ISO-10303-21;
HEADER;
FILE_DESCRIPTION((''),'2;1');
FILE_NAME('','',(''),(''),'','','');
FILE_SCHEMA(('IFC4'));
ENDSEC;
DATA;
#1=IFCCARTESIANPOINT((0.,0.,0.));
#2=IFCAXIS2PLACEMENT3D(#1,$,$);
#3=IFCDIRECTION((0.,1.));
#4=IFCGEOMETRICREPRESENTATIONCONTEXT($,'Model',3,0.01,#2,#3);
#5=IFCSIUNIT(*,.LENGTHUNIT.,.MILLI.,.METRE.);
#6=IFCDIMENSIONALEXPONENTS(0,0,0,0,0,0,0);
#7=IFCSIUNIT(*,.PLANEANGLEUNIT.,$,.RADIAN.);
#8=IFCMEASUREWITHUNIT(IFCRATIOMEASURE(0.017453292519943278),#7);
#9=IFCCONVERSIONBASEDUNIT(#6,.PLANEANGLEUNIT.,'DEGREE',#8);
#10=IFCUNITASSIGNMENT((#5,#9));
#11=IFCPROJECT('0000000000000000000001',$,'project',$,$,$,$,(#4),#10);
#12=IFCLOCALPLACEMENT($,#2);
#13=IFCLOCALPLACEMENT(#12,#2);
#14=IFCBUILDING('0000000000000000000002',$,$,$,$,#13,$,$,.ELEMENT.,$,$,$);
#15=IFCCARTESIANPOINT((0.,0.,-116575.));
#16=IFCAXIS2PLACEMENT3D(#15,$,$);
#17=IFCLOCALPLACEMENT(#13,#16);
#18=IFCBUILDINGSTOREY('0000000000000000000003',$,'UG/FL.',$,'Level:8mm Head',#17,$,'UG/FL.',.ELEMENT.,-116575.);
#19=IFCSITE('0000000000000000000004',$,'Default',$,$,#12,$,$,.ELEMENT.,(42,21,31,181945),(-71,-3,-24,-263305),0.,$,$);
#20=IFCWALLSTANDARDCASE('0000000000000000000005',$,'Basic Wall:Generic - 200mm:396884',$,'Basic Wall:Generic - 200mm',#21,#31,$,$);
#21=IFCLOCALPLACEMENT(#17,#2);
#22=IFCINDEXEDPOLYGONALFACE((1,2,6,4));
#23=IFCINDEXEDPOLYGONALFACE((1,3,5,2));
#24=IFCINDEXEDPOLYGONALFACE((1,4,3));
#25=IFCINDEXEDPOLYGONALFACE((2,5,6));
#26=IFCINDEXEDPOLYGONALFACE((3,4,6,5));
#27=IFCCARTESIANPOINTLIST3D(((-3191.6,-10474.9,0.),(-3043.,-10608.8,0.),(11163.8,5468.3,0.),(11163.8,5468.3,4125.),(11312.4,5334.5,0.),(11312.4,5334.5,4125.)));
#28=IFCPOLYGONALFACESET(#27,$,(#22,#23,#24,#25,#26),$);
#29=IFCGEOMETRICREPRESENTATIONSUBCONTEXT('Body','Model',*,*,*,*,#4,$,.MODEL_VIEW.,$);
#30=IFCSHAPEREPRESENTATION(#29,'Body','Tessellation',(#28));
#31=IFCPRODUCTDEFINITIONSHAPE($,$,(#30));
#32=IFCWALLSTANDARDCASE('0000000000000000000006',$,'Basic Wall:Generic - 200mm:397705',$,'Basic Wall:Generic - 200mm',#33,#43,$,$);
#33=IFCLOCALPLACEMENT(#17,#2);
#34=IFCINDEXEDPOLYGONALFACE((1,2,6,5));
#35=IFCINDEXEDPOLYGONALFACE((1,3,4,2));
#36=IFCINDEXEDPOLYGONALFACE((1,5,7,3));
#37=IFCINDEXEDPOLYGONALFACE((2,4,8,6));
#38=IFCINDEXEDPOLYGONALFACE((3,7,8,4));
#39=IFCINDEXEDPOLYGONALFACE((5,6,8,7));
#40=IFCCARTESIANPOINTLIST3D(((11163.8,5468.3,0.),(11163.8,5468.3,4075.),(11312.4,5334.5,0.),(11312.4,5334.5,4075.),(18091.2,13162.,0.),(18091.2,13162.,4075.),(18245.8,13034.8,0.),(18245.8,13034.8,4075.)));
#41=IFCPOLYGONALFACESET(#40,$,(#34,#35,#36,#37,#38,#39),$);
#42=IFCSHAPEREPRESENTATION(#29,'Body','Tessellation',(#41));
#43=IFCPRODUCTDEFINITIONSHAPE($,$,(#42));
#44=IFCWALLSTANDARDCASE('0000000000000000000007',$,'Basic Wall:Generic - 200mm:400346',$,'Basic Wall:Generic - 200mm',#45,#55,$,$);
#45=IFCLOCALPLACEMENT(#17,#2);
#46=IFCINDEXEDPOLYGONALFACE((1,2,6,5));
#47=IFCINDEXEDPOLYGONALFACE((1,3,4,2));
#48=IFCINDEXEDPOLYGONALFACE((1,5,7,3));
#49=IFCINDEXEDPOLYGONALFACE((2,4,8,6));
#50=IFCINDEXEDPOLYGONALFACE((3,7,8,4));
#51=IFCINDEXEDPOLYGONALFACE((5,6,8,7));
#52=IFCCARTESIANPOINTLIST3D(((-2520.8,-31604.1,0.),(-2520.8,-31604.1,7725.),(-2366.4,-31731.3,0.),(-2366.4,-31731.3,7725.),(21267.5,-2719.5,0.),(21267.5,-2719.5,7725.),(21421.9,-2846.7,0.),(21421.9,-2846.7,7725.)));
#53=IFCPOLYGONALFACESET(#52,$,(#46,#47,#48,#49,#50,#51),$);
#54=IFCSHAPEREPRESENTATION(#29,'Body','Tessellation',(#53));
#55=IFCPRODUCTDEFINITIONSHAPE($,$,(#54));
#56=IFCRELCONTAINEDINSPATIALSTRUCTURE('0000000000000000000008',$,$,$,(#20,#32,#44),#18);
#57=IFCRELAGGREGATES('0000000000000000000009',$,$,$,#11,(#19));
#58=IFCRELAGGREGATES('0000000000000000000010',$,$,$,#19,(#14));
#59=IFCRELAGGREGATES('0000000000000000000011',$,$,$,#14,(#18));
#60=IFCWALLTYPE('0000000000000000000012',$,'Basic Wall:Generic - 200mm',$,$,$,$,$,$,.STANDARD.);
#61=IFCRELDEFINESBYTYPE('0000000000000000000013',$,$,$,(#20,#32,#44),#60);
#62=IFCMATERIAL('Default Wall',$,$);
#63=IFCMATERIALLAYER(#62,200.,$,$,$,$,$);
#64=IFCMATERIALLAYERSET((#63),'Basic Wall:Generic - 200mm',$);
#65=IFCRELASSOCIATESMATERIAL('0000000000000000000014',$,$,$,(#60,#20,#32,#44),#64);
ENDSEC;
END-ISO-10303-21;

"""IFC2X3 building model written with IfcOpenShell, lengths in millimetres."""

from ifc_helpers import new_model, entity, si_unit, converted_unit, direction, frame, frame_2d, origin, place, context, subcontext, project, spatial, polyline, rectangle, outline, extrude, clip, halfspace, material, layer, layer_set, layer_usage, type_object, element, save


model = new_model("IFC2X3")

# Units and contexts
model_context = context("Model", 3, precision=0.01, world=origin(), true_north=direction((0.0, 1.0)))
body_context = subcontext(model_context, "Body", "Model", "MODEL_VIEW")
ifc_project = project(units=[si_unit("LENGTHUNIT", "METRE", prefix="MILLI"), converted_unit("PLANEANGLEUNIT", "DEGREE", entity("IfcRatioMeasure", 0.017453292519943278), si_unit("PLANEANGLEUNIT", "RADIAN"), dimensions=[0, 0, 0, 0, 0, 0, 0])], contexts=[model_context])

# Site, building, storey
site_placement = place(None, origin())
site = spatial("IfcSite", under=ifc_project, at=site_placement, Name="Default", CompositionType="ELEMENT", RefLatitude=(42, 21, 31, 181945), RefLongitude=(-71, -3, -24, -263305), RefElevation=0.0)
building_placement = place(site_placement, origin())
building = spatial("IfcBuilding", under=site, at=building_placement, CompositionType="ELEMENT")
storey_placement = place(building_placement, frame((0.0, 0.0, -116575.0)))
storey = spatial("IfcBuildingStorey", under=building, at=storey_placement, Name="UG/FL.", ObjectType="Level:8mm Head", LongName="UG/FL.", CompositionType="ELEMENT", Elevation=-116575.0)

# Walls
ifc_material = material(Name="Default Wall")
ifc_layer = layer(ifc_material, 200.0)
ifc_layer_set = layer_set([ifc_layer], Name="Basic Wall:Generic - 200mm")
ifc_layer_usage = layer_usage(ifc_layer_set, "AXIS2", "NEGATIVE", 100.0)
wall_type = type_object("IfcWallType", Name="Basic Wall:Generic - 200mm", PredefinedType="STANDARD", material=ifc_layer_set)
wall_1_placement = place(storey_placement, frame((-3117.3, -10541.9, 0.0), z_axis=(0.0, 0.0, 1.0), x_axis=(0.669131, 0.743145, 0.0)))
element("IfcWallStandardCase", 1, at=wall_1_placement, inside=storey, type_object=wall_type, material=ifc_layer_usage, Name="Basic Wall:Generic - 200mm:396884", ObjectType="Basic Wall:Generic - 200mm", context=body_context, shape_type="Clipping", body=[
    clip(extrude(rectangle(XDim=36016.3, YDim=200.0, at=frame_2d((3445.6, 0.0), x_axis=(1.0, 0.0))), origin(), (0.0, 0.0, 1.0), 4125.0), halfspace(frame((0.0, -100.0, 0.0), z_axis=(-0.188816, 0.0, 0.982013), x_axis=(0.0, 1.0, 0.0)), False)),
])
wall_2_placement = place(storey_placement, frame((11238.1, 5401.4, 0.0), z_axis=(0.0, 0.0, 1.0), x_axis=(0.669131, 0.743145, 0.0)))
element("IfcWallStandardCase", 2, at=wall_2_placement, inside=storey, type_object=wall_type, material=ifc_layer_usage, Name="Basic Wall:Generic - 200mm:397705", ObjectType="Basic Wall:Generic - 200mm", context=body_context, shape_type="SweptSolid", body=[
    extrude(outline(polyline([(10361.9, -100.0), (10352.9, 100.0), (0.0, 100.0), (0.0, -100.0), (10361.9, -100.0)])), origin(), (0.0, 0.0, 1.0), 4075.0),
])
wall_3_placement = place(storey_placement, frame((21344.7, -2783.1, 0.0), z_axis=(0.0, 0.0, 1.0), x_axis=(-0.635723, -0.771917, 0.0)))
element("IfcWallStandardCase", 3, at=wall_3_placement, inside=storey, type_object=wall_type, material=ifc_layer_usage, Name="Basic Wall:Generic - 200mm:400346", ObjectType="Basic Wall:Generic - 200mm", context=body_context, shape_type="SweptSolid", body=[
    extrude(rectangle(XDim=37419.3, YDim=200.0, at=frame_2d((18709.7, 0.0), x_axis=(-1.0, 0.0))), origin(), (0.0, 0.0, 1.0), 7725.0),
])

save(model, "model.ifc")
